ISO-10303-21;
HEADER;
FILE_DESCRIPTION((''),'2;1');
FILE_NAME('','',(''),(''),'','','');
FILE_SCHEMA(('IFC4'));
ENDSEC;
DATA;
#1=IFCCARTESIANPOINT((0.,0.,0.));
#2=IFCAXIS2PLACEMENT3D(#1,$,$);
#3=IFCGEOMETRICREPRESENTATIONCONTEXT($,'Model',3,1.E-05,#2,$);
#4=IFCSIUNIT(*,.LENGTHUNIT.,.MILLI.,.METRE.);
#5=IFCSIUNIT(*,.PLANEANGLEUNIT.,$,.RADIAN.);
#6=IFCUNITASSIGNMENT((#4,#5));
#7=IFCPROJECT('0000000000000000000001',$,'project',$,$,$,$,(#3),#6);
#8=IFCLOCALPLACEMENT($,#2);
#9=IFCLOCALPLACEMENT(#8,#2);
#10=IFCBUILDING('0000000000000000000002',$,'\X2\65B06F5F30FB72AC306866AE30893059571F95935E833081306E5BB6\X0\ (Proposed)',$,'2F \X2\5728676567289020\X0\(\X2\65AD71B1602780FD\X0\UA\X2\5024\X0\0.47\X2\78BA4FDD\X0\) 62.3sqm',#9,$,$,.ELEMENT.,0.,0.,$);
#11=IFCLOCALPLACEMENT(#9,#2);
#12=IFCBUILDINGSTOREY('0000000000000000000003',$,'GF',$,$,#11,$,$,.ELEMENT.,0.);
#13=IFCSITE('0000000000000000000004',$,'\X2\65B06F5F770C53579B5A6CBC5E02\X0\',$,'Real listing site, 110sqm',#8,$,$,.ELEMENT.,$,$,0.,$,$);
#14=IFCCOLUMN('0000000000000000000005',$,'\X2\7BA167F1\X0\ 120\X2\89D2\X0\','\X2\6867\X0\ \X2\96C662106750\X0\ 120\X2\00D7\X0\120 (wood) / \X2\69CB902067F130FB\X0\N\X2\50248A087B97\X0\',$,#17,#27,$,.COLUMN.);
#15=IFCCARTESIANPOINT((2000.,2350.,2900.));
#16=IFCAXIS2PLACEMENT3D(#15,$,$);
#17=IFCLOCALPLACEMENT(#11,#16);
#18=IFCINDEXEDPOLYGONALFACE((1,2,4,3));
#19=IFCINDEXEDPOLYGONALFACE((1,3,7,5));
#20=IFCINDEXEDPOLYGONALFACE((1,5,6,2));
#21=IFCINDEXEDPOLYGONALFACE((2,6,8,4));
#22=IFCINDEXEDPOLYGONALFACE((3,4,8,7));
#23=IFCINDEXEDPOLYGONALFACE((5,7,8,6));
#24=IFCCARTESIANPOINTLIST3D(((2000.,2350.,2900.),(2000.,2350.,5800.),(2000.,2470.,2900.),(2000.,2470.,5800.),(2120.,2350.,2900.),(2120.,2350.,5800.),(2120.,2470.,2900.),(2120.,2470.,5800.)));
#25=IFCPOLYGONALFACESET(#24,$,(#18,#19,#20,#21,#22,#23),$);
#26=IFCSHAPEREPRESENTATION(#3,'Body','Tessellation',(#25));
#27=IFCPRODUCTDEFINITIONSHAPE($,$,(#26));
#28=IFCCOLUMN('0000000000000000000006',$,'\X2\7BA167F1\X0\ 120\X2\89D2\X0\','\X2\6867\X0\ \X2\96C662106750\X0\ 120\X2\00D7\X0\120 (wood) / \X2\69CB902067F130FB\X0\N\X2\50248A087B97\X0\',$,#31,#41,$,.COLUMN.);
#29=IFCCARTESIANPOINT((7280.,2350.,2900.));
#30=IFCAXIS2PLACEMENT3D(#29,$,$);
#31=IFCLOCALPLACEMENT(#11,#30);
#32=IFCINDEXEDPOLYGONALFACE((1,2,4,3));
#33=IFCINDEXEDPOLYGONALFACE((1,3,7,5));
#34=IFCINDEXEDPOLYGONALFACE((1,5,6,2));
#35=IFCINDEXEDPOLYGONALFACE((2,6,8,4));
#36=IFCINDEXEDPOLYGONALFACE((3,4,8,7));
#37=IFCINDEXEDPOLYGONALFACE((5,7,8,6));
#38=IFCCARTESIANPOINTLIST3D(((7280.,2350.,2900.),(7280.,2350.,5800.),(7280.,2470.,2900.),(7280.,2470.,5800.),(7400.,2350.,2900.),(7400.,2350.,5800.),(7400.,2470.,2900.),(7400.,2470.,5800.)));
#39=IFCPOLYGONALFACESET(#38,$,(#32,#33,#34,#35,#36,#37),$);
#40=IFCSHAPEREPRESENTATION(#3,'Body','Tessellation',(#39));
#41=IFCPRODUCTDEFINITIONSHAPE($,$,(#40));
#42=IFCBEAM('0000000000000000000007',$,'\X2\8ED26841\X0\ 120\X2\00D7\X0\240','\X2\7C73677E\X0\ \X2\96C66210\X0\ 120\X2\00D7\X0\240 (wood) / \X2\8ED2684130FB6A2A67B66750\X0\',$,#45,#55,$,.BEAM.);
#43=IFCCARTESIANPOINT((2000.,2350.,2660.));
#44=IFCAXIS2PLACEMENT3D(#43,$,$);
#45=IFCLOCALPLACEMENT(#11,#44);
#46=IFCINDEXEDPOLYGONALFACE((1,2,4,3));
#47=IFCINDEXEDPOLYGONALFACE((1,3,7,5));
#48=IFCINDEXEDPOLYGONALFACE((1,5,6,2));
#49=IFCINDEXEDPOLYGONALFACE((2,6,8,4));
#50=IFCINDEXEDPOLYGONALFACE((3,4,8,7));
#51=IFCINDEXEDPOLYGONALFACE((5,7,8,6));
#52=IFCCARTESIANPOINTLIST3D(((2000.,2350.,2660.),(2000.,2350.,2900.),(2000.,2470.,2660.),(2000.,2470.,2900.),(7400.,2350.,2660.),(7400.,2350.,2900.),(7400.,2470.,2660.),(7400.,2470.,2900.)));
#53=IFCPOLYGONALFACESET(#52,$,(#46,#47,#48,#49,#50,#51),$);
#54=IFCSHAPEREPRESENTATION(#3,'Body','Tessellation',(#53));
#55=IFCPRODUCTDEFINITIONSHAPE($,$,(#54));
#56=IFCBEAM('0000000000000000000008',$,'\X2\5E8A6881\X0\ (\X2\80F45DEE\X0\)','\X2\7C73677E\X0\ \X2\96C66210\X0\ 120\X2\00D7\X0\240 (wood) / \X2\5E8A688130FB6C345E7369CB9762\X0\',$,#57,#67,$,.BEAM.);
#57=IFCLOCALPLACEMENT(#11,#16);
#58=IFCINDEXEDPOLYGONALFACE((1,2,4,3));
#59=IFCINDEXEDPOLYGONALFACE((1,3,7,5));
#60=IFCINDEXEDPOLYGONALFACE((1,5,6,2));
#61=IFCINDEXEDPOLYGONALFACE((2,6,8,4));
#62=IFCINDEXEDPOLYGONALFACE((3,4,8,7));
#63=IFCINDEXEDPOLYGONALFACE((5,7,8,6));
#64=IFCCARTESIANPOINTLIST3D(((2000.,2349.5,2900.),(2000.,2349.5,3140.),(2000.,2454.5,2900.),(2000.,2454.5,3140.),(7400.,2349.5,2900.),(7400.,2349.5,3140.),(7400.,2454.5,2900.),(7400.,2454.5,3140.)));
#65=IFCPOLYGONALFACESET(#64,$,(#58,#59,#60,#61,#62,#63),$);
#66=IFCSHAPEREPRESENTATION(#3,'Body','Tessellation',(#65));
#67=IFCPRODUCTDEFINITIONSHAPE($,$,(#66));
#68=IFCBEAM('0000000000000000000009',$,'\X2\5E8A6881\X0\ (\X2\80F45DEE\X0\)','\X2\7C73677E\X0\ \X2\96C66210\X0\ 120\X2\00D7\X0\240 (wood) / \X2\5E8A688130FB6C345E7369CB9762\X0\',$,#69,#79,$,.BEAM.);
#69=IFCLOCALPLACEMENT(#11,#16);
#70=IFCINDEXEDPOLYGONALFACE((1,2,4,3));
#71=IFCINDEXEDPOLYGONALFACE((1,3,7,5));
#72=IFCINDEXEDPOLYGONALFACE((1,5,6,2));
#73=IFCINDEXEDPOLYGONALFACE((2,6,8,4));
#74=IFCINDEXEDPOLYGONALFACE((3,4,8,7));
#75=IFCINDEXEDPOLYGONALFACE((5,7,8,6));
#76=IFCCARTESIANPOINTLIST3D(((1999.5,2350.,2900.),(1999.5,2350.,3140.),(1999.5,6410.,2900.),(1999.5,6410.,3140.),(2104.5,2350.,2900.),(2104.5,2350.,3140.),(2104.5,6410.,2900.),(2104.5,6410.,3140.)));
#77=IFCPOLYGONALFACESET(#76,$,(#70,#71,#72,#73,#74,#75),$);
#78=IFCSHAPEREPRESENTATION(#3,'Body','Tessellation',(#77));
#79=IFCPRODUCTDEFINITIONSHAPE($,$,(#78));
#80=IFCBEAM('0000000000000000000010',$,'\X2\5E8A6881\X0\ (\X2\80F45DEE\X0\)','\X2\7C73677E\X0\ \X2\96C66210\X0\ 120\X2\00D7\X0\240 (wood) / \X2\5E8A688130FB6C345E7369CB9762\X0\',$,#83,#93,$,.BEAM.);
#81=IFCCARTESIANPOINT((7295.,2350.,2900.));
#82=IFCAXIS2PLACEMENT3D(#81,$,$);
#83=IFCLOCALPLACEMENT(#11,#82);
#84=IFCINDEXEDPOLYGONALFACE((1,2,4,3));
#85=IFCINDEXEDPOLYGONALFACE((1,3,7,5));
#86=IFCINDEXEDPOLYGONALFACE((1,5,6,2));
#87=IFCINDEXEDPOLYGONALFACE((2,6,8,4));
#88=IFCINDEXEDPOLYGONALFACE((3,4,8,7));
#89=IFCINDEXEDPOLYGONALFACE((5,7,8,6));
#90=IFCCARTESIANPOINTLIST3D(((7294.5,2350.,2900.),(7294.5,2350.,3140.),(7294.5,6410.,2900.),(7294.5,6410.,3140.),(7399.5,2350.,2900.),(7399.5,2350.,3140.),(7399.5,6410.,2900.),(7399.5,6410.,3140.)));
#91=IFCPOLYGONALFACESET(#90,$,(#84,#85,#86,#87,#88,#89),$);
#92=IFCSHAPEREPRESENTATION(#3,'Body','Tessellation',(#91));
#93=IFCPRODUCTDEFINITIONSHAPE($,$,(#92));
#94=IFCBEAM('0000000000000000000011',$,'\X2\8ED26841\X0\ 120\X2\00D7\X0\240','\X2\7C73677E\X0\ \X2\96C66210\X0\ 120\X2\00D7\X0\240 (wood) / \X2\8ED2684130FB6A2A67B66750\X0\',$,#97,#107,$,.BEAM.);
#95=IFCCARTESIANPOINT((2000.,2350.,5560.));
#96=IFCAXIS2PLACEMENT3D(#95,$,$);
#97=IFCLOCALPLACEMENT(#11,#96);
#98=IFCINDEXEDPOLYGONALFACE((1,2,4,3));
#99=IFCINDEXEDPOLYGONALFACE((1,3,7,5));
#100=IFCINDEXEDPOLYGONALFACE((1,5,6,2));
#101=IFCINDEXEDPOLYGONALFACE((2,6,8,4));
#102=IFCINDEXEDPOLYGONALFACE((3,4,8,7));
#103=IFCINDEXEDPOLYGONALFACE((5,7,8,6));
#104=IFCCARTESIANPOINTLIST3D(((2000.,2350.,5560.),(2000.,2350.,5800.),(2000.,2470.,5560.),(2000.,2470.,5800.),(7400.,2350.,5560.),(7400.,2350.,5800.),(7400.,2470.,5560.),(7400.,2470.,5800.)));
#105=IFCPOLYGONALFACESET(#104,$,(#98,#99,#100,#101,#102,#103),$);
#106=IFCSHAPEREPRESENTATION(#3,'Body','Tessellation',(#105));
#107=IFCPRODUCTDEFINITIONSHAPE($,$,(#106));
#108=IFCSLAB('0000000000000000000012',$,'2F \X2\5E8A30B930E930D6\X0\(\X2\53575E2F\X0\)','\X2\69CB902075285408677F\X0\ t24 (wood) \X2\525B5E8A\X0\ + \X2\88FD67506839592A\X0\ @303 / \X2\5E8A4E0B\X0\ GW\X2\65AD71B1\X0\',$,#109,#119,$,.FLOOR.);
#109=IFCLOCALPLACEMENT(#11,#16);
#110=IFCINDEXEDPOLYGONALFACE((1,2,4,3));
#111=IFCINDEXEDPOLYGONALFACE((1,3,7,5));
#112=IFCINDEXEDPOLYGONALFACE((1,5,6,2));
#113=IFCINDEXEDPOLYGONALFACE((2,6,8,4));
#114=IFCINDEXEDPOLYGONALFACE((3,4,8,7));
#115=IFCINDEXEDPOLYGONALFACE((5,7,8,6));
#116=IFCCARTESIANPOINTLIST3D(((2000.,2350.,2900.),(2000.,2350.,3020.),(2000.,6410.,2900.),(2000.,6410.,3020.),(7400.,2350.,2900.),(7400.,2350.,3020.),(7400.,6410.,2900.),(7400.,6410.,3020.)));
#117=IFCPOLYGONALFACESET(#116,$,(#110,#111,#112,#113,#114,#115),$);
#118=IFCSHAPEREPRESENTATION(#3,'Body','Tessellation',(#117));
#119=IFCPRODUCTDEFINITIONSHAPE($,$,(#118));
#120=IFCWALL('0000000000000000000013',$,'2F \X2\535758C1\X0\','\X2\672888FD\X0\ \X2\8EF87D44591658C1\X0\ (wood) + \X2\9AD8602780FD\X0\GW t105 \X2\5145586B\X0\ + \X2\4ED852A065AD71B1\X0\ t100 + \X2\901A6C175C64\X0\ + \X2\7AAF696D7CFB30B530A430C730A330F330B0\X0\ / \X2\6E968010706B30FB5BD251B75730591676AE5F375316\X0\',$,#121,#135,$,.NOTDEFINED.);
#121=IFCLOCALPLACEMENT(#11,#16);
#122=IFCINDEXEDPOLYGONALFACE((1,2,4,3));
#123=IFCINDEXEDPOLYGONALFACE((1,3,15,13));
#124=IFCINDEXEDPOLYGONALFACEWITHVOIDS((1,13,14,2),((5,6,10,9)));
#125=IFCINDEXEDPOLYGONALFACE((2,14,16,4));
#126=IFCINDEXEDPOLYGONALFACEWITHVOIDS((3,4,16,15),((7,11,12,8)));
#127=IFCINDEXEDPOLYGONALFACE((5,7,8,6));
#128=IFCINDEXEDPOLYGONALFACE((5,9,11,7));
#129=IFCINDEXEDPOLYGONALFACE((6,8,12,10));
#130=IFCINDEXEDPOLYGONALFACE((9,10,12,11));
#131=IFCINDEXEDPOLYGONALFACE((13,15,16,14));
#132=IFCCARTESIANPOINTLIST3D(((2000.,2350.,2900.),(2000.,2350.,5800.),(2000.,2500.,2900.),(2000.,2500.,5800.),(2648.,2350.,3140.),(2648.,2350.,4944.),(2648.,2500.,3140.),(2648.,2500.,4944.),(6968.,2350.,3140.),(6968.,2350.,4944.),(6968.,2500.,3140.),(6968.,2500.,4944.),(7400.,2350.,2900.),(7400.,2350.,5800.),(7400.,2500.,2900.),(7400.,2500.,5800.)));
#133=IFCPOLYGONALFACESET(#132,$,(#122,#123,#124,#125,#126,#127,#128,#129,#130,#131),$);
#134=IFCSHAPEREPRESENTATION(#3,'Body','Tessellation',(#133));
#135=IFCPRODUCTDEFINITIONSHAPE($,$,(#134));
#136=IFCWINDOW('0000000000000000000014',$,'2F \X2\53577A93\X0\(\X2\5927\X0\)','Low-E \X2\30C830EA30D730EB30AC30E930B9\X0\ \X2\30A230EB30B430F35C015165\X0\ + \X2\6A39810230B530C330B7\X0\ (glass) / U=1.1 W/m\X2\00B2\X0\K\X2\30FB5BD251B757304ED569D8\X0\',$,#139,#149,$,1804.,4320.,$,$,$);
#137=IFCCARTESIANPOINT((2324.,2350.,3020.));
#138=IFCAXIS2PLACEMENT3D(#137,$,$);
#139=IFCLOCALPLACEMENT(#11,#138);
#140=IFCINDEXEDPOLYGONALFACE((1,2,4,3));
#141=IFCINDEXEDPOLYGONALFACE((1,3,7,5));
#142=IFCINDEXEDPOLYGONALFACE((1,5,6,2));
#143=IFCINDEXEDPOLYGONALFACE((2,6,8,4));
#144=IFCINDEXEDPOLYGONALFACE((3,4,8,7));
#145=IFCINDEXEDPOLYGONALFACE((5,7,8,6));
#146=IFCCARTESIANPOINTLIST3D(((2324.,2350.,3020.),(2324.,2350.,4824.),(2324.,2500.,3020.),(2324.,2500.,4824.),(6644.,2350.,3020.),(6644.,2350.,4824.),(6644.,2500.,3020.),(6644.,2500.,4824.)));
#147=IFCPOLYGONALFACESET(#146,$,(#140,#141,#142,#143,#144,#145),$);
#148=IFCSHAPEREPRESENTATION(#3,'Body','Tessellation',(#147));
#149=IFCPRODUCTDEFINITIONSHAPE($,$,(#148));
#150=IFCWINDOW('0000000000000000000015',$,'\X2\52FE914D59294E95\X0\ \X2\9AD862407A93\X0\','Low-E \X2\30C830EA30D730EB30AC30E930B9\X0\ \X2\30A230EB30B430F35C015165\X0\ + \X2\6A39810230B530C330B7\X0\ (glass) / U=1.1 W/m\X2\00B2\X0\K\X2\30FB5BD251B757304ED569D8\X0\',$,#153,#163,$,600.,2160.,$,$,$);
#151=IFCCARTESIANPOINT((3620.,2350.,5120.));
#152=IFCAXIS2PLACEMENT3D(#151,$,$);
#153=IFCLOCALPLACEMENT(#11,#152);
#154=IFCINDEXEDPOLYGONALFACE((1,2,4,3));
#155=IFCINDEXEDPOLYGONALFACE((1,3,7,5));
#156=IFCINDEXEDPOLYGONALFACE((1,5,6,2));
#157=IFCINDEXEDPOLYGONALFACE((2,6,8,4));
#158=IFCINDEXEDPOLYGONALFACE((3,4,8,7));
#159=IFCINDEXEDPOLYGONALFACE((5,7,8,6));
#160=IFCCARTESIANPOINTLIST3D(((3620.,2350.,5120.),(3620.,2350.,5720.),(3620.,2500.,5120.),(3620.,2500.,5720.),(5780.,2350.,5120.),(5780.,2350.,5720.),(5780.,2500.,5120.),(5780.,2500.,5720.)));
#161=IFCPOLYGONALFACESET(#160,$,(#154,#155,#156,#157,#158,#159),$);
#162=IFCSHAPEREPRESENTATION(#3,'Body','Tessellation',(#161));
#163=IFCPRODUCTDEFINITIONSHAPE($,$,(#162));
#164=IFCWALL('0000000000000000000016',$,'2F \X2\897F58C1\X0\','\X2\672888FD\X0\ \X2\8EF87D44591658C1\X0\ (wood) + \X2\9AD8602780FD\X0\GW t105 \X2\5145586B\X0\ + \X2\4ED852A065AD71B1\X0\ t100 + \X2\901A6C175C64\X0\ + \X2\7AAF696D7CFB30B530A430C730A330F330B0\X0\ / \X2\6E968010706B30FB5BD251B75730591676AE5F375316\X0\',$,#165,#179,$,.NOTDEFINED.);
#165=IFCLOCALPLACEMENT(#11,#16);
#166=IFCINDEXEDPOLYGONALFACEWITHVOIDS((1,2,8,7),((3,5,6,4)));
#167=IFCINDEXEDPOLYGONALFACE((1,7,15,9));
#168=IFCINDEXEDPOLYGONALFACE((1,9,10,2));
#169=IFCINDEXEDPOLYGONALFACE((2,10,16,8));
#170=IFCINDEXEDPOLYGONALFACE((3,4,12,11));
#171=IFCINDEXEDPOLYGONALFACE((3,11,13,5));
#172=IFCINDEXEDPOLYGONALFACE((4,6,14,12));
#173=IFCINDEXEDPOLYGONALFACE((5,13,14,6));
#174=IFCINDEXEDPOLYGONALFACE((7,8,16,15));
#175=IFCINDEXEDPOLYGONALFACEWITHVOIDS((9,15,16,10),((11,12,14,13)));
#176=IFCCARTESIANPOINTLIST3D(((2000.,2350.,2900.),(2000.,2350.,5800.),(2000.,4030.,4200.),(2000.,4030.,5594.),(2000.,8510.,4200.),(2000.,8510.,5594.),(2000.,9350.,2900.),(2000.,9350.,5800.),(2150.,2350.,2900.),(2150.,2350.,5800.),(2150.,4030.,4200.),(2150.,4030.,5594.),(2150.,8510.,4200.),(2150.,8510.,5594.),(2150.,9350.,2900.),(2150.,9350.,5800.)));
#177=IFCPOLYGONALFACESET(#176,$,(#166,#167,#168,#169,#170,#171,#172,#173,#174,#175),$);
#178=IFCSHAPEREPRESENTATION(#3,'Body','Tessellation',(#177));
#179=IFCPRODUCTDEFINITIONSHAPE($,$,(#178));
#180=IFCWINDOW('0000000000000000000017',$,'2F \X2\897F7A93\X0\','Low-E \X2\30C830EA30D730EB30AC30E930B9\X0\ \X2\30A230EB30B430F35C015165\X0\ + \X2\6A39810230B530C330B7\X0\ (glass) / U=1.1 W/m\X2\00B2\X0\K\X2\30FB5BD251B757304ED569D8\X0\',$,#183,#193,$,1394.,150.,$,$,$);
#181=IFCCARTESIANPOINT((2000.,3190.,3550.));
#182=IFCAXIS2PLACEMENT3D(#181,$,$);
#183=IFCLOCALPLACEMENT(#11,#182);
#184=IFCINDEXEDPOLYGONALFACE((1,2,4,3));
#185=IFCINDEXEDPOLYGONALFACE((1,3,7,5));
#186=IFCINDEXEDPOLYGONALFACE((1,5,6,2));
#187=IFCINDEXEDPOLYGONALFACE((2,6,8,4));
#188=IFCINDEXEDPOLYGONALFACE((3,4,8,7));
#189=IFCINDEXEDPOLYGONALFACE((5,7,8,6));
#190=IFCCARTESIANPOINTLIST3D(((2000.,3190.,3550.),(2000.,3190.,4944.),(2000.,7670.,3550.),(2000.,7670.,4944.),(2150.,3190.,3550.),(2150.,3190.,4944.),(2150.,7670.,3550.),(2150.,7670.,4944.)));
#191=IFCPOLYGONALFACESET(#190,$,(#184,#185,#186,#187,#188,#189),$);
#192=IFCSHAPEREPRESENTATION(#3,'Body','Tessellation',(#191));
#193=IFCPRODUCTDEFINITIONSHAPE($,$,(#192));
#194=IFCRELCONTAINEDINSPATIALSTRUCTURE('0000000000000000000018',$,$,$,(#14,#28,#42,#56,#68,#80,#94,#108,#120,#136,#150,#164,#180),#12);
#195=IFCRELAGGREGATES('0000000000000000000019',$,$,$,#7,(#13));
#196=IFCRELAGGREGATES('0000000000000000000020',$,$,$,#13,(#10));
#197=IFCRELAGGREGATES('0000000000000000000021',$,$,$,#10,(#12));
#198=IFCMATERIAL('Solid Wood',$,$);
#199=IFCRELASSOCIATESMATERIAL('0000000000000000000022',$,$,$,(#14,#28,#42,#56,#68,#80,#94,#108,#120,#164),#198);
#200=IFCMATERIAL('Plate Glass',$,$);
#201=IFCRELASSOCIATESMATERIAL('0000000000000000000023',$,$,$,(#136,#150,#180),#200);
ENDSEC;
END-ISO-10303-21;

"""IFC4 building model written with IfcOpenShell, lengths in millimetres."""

from ifc_helpers import new_model, si_unit, frame, frame_2d, origin, place, context, project, spatial, rectangle, extrude, material, element, fill, save


model = new_model("IFC4")

# Units and contexts
model_context = context("Model", 3, precision=1e-05, world=origin())
ifc_project = project(units=[si_unit("LENGTHUNIT", "METRE", prefix="MILLI"), si_unit("PLANEANGLEUNIT", "RADIAN")], contexts=[model_context])

# Site, building, storey
site_placement = place(None, origin())
site = spatial("IfcSite", under=ifc_project, at=site_placement, Name="新潟県南魚沼市", ObjectType="Real listing site, 110sqm", CompositionType="ELEMENT", RefElevation=0.0)
building_placement = place(site_placement, origin())
building = spatial("IfcBuilding", under=site, at=building_placement, Name="新潟・犬と暮らす土間広めの家 (Proposed)", ObjectType="2F 在来木造(断熱性能UA値0.47確保) 62.3sqm", CompositionType="ELEMENT", ElevationOfRefHeight=0.0, ElevationOfTerrain=0.0)
storey_placement = place(building_placement, origin())
storey = spatial("IfcBuildingStorey", under=building, at=storey_placement, Name="GF", CompositionType="ELEMENT", Elevation=0.0)

# Columns
ifc_material_1 = material(Name="Solid Wood")
column_1_placement = place(storey_placement, frame((2000.0, 2350.0, 2900.0)))
element("IfcColumn", 1, at=column_1_placement, inside=storey, material=ifc_material_1, Name="管柱 120角", Description="桧 集成材 120×120 (wood) / 構造柱・N値計算", PredefinedType="COLUMN", context=model_context, shape_type="SweptSolid", body=[
    extrude(rectangle(XDim=120.0, YDim=120.0, at=frame_2d((60.0, 60.0))), frame((2000.0, 2350.0, 2900.0)), (0.0, 0.0, 1.0), 2900.0),
])
column_2_placement = place(storey_placement, frame((7280.0, 2350.0, 2900.0)))
element("IfcColumn", 2, at=column_2_placement, inside=storey, material=ifc_material_1, Name="管柱 120角", Description="桧 集成材 120×120 (wood) / 構造柱・N値計算", PredefinedType="COLUMN", context=model_context, shape_type="SweptSolid", body=[
    extrude(rectangle(XDim=120.0, YDim=120.0, at=frame_2d((60.0, 60.0))), frame((7280.0, 2350.0, 2900.0)), (0.0, 0.0, 1.0), 2900.0),
])

# Beams
beam_1_placement = place(storey_placement, frame((2000.0, 2350.0, 2660.0)))
element("IfcBeam", 3, at=beam_1_placement, inside=storey, material=ifc_material_1, Name="軒桁 120×240", Description="米松 集成 120×240 (wood) / 軒桁・横架材", PredefinedType="BEAM", context=model_context, shape_type="SweptSolid", body=[
    extrude(rectangle(XDim=5400.0, YDim=120.0, at=frame_2d((2700.0, 60.0))), frame((2000.0, 2350.0, 2660.0)), (0.0, 0.0, 1.0), 240.0),
])
beam_2_placement = place(storey_placement, frame((2000.0, 2350.0, 2900.0)))
element("IfcBeam", 4, at=beam_2_placement, inside=storey, material=ifc_material_1, Name="床梁 (胴差)", Description="米松 集成 120×240 (wood) / 床梁・水平構面", PredefinedType="BEAM", context=model_context, shape_type="SweptSolid", body=[
    extrude(rectangle(XDim=5400.0, YDim=105.0, at=frame_2d((2700.0, 52.0))), frame((2000.0, 2350.0, 2900.0)), (0.0, 0.0, 1.0), 240.0),
])
beam_3_placement = place(storey_placement, frame((2000.0, 2350.0, 2900.0)))
element("IfcBeam", 5, at=beam_3_placement, inside=storey, material=ifc_material_1, Name="床梁 (胴差)", Description="米松 集成 120×240 (wood) / 床梁・水平構面", PredefinedType="BEAM", context=model_context, shape_type="SweptSolid", body=[
    extrude(rectangle(XDim=105.0, YDim=4060.0, at=frame_2d((52.0, 2030.0))), frame((2000.0, 2350.0, 2900.0)), (0.0, 0.0, 1.0), 240.0),
])
beam_4_placement = place(storey_placement, frame((7295.0, 2350.0, 2900.0)))
element("IfcBeam", 6, at=beam_4_placement, inside=storey, material=ifc_material_1, Name="床梁 (胴差)", Description="米松 集成 120×240 (wood) / 床梁・水平構面", PredefinedType="BEAM", context=model_context, shape_type="SweptSolid", body=[
    extrude(rectangle(XDim=105.0, YDim=4060.0, at=frame_2d((52.0, 2030.0))), frame((7295.0, 2350.0, 2900.0)), (0.0, 0.0, 1.0), 240.0),
])
beam_5_placement = place(storey_placement, frame((2000.0, 2350.0, 5560.0)))
element("IfcBeam", 7, at=beam_5_placement, inside=storey, material=ifc_material_1, Name="軒桁 120×240", Description="米松 集成 120×240 (wood) / 軒桁・横架材", PredefinedType="BEAM", context=model_context, shape_type="SweptSolid", body=[
    extrude(rectangle(XDim=5400.0, YDim=120.0, at=frame_2d((2700.0, 60.0))), frame((2000.0, 2350.0, 5560.0)), (0.0, 0.0, 1.0), 240.0),
])

# Slab
slab_placement = place(storey_placement, frame((2000.0, 2350.0, 2900.0)))
element("IfcSlab", 8, at=slab_placement, inside=storey, material=ifc_material_1, Name="2F 床スラブ(南帯)", Description="構造用合板 t24 (wood) 剛床 + 製材根太 @303 / 床下 GW断熱", PredefinedType="FLOOR", context=model_context, shape_type="SweptSolid", body=[
    extrude(rectangle(XDim=5400.0, YDim=4060.0, at=frame_2d((2700.0, 2030.0))), frame((2000.0, 2350.0, 2900.0)), (0.0, 0.0, 1.0), 120.0),
])

# Wall, openings, windows
wall_1_placement = place(storey_placement, frame((2000.0, 2350.0, 2900.0)))
wall_1 = element("IfcWall", 9, at=wall_1_placement, inside=storey, material=ifc_material_1, Name="2F 南壁", Description="木製 軸組外壁 (wood) + 高性能GW t105 充填 + 付加断熱 t100 + 通気層 + 窯業系サイディング / 準耐火・寒冷地外皮強化", PredefinedType="NOTDEFINED", context=model_context, shape_type="SweptSolid", body=[
    extrude(rectangle(XDim=5400.0, YDim=150.0, at=frame_2d((2700.0, 75.0))), frame((2000.0, 2350.0, 2900.0)), (0.0, 0.0, 1.0), 2900.0),
])
opening_1_placement = place(storey_placement, frame((2324.0, 2350.0, 3020.0)))
opening_1 = element("IfcOpeningElement", 10, at=opening_1_placement, cuts=wall_1, PredefinedType="NOTDEFINED", context=model_context, shape_type="SweptSolid", body=[
    extrude(rectangle(XDim=4320.0, YDim=150.0, at=frame_2d((2160.0, 75.0))), frame((2324.0, 2350.0, 3020.0)), (0.0, 0.0, 1.0), 1804.0),
])
opening_2_placement = place(storey_placement, frame((3620.0, 2350.0, 5120.0)))
opening_2 = element("IfcOpeningElement", 11, at=opening_2_placement, cuts=wall_1, PredefinedType="NOTDEFINED", context=model_context, shape_type="SweptSolid", body=[
    extrude(rectangle(XDim=2160.0, YDim=150.0, at=frame_2d((1080.0, 75.0))), frame((3620.0, 2350.0, 5120.0)), (0.0, 0.0, 1.0), 600.0),
])
ifc_material_2 = material(Name="Plate Glass")
window_1_placement = place(storey_placement, frame((2324.0, 2350.0, 3020.0)))
window_1 = element("IfcWindow", 12, at=window_1_placement, inside=storey, material=ifc_material_2, Name="2F 南窓(大)", Description="Low-E トリプルガラス アルゴン封入 + 樹脂サッシ (glass) / U=1.1 W/m²K・寒冷地仕様", OverallHeight=1804.0, OverallWidth=4320.0, context=model_context, shape_type="SweptSolid", body=[
    extrude(rectangle(XDim=4320.0, YDim=150.0, at=frame_2d((2160.0, 75.0))), frame((2324.0, 2350.0, 3020.0)), (0.0, 0.0, 1.0), 1804.0),
])
fill(opening_1, window_1)
window_2_placement = place(storey_placement, frame((3620.0, 2350.0, 5120.0)))
window_2 = element("IfcWindow", 13, at=window_2_placement, inside=storey, material=ifc_material_2, Name="勾配天井 高所窓", Description="Low-E トリプルガラス アルゴン封入 + 樹脂サッシ (glass) / U=1.1 W/m²K・寒冷地仕様", OverallHeight=600.0, OverallWidth=2160.0, context=model_context, shape_type="SweptSolid", body=[
    extrude(rectangle(XDim=2160.0, YDim=150.0, at=frame_2d((1080.0, 75.0))), frame((3620.0, 2350.0, 5120.0)), (0.0, 0.0, 1.0), 600.0),
])
fill(opening_2, window_2)

# Wall, opening, window
wall_2_placement = place(storey_placement, frame((2000.0, 2350.0, 2900.0)))
wall_2 = element("IfcWall", 14, at=wall_2_placement, inside=storey, material=ifc_material_1, Name="2F 西壁", Description="木製 軸組外壁 (wood) + 高性能GW t105 充填 + 付加断熱 t100 + 通気層 + 窯業系サイディング / 準耐火・寒冷地外皮強化", PredefinedType="NOTDEFINED", context=model_context, shape_type="SweptSolid", body=[
    extrude(rectangle(XDim=150.0, YDim=7000.0, at=frame_2d((75.0, 3500.0))), frame((2000.0, 2350.0, 2900.0)), (0.0, 0.0, 1.0), 2900.0),
])
opening_3_placement = place(storey_placement, frame((2000.0, 3190.0, 3550.0)))
opening_3 = element("IfcOpeningElement", 15, at=opening_3_placement, cuts=wall_2, PredefinedType="NOTDEFINED", context=model_context, shape_type="SweptSolid", body=[
    extrude(rectangle(XDim=150.0, YDim=4480.0, at=frame_2d((75.0, 2240.0))), frame((2000.0, 3190.0, 3550.0)), (0.0, 0.0, 1.0), 1394.0),
])
window_3_placement = place(storey_placement, frame((2000.0, 3190.0, 3550.0)))
window_3 = element("IfcWindow", 16, at=window_3_placement, inside=storey, material=ifc_material_2, Name="2F 西窓", Description="Low-E トリプルガラス アルゴン封入 + 樹脂サッシ (glass) / U=1.1 W/m²K・寒冷地仕様", OverallHeight=1394.0, OverallWidth=150.0, context=model_context, shape_type="SweptSolid", body=[
    extrude(rectangle(XDim=150.0, YDim=4480.0, at=frame_2d((75.0, 2240.0))), frame((2000.0, 3190.0, 3550.0)), (0.0, 0.0, 1.0), 1394.0),
])
fill(opening_3, window_3)

save(model, "model.ifc")
